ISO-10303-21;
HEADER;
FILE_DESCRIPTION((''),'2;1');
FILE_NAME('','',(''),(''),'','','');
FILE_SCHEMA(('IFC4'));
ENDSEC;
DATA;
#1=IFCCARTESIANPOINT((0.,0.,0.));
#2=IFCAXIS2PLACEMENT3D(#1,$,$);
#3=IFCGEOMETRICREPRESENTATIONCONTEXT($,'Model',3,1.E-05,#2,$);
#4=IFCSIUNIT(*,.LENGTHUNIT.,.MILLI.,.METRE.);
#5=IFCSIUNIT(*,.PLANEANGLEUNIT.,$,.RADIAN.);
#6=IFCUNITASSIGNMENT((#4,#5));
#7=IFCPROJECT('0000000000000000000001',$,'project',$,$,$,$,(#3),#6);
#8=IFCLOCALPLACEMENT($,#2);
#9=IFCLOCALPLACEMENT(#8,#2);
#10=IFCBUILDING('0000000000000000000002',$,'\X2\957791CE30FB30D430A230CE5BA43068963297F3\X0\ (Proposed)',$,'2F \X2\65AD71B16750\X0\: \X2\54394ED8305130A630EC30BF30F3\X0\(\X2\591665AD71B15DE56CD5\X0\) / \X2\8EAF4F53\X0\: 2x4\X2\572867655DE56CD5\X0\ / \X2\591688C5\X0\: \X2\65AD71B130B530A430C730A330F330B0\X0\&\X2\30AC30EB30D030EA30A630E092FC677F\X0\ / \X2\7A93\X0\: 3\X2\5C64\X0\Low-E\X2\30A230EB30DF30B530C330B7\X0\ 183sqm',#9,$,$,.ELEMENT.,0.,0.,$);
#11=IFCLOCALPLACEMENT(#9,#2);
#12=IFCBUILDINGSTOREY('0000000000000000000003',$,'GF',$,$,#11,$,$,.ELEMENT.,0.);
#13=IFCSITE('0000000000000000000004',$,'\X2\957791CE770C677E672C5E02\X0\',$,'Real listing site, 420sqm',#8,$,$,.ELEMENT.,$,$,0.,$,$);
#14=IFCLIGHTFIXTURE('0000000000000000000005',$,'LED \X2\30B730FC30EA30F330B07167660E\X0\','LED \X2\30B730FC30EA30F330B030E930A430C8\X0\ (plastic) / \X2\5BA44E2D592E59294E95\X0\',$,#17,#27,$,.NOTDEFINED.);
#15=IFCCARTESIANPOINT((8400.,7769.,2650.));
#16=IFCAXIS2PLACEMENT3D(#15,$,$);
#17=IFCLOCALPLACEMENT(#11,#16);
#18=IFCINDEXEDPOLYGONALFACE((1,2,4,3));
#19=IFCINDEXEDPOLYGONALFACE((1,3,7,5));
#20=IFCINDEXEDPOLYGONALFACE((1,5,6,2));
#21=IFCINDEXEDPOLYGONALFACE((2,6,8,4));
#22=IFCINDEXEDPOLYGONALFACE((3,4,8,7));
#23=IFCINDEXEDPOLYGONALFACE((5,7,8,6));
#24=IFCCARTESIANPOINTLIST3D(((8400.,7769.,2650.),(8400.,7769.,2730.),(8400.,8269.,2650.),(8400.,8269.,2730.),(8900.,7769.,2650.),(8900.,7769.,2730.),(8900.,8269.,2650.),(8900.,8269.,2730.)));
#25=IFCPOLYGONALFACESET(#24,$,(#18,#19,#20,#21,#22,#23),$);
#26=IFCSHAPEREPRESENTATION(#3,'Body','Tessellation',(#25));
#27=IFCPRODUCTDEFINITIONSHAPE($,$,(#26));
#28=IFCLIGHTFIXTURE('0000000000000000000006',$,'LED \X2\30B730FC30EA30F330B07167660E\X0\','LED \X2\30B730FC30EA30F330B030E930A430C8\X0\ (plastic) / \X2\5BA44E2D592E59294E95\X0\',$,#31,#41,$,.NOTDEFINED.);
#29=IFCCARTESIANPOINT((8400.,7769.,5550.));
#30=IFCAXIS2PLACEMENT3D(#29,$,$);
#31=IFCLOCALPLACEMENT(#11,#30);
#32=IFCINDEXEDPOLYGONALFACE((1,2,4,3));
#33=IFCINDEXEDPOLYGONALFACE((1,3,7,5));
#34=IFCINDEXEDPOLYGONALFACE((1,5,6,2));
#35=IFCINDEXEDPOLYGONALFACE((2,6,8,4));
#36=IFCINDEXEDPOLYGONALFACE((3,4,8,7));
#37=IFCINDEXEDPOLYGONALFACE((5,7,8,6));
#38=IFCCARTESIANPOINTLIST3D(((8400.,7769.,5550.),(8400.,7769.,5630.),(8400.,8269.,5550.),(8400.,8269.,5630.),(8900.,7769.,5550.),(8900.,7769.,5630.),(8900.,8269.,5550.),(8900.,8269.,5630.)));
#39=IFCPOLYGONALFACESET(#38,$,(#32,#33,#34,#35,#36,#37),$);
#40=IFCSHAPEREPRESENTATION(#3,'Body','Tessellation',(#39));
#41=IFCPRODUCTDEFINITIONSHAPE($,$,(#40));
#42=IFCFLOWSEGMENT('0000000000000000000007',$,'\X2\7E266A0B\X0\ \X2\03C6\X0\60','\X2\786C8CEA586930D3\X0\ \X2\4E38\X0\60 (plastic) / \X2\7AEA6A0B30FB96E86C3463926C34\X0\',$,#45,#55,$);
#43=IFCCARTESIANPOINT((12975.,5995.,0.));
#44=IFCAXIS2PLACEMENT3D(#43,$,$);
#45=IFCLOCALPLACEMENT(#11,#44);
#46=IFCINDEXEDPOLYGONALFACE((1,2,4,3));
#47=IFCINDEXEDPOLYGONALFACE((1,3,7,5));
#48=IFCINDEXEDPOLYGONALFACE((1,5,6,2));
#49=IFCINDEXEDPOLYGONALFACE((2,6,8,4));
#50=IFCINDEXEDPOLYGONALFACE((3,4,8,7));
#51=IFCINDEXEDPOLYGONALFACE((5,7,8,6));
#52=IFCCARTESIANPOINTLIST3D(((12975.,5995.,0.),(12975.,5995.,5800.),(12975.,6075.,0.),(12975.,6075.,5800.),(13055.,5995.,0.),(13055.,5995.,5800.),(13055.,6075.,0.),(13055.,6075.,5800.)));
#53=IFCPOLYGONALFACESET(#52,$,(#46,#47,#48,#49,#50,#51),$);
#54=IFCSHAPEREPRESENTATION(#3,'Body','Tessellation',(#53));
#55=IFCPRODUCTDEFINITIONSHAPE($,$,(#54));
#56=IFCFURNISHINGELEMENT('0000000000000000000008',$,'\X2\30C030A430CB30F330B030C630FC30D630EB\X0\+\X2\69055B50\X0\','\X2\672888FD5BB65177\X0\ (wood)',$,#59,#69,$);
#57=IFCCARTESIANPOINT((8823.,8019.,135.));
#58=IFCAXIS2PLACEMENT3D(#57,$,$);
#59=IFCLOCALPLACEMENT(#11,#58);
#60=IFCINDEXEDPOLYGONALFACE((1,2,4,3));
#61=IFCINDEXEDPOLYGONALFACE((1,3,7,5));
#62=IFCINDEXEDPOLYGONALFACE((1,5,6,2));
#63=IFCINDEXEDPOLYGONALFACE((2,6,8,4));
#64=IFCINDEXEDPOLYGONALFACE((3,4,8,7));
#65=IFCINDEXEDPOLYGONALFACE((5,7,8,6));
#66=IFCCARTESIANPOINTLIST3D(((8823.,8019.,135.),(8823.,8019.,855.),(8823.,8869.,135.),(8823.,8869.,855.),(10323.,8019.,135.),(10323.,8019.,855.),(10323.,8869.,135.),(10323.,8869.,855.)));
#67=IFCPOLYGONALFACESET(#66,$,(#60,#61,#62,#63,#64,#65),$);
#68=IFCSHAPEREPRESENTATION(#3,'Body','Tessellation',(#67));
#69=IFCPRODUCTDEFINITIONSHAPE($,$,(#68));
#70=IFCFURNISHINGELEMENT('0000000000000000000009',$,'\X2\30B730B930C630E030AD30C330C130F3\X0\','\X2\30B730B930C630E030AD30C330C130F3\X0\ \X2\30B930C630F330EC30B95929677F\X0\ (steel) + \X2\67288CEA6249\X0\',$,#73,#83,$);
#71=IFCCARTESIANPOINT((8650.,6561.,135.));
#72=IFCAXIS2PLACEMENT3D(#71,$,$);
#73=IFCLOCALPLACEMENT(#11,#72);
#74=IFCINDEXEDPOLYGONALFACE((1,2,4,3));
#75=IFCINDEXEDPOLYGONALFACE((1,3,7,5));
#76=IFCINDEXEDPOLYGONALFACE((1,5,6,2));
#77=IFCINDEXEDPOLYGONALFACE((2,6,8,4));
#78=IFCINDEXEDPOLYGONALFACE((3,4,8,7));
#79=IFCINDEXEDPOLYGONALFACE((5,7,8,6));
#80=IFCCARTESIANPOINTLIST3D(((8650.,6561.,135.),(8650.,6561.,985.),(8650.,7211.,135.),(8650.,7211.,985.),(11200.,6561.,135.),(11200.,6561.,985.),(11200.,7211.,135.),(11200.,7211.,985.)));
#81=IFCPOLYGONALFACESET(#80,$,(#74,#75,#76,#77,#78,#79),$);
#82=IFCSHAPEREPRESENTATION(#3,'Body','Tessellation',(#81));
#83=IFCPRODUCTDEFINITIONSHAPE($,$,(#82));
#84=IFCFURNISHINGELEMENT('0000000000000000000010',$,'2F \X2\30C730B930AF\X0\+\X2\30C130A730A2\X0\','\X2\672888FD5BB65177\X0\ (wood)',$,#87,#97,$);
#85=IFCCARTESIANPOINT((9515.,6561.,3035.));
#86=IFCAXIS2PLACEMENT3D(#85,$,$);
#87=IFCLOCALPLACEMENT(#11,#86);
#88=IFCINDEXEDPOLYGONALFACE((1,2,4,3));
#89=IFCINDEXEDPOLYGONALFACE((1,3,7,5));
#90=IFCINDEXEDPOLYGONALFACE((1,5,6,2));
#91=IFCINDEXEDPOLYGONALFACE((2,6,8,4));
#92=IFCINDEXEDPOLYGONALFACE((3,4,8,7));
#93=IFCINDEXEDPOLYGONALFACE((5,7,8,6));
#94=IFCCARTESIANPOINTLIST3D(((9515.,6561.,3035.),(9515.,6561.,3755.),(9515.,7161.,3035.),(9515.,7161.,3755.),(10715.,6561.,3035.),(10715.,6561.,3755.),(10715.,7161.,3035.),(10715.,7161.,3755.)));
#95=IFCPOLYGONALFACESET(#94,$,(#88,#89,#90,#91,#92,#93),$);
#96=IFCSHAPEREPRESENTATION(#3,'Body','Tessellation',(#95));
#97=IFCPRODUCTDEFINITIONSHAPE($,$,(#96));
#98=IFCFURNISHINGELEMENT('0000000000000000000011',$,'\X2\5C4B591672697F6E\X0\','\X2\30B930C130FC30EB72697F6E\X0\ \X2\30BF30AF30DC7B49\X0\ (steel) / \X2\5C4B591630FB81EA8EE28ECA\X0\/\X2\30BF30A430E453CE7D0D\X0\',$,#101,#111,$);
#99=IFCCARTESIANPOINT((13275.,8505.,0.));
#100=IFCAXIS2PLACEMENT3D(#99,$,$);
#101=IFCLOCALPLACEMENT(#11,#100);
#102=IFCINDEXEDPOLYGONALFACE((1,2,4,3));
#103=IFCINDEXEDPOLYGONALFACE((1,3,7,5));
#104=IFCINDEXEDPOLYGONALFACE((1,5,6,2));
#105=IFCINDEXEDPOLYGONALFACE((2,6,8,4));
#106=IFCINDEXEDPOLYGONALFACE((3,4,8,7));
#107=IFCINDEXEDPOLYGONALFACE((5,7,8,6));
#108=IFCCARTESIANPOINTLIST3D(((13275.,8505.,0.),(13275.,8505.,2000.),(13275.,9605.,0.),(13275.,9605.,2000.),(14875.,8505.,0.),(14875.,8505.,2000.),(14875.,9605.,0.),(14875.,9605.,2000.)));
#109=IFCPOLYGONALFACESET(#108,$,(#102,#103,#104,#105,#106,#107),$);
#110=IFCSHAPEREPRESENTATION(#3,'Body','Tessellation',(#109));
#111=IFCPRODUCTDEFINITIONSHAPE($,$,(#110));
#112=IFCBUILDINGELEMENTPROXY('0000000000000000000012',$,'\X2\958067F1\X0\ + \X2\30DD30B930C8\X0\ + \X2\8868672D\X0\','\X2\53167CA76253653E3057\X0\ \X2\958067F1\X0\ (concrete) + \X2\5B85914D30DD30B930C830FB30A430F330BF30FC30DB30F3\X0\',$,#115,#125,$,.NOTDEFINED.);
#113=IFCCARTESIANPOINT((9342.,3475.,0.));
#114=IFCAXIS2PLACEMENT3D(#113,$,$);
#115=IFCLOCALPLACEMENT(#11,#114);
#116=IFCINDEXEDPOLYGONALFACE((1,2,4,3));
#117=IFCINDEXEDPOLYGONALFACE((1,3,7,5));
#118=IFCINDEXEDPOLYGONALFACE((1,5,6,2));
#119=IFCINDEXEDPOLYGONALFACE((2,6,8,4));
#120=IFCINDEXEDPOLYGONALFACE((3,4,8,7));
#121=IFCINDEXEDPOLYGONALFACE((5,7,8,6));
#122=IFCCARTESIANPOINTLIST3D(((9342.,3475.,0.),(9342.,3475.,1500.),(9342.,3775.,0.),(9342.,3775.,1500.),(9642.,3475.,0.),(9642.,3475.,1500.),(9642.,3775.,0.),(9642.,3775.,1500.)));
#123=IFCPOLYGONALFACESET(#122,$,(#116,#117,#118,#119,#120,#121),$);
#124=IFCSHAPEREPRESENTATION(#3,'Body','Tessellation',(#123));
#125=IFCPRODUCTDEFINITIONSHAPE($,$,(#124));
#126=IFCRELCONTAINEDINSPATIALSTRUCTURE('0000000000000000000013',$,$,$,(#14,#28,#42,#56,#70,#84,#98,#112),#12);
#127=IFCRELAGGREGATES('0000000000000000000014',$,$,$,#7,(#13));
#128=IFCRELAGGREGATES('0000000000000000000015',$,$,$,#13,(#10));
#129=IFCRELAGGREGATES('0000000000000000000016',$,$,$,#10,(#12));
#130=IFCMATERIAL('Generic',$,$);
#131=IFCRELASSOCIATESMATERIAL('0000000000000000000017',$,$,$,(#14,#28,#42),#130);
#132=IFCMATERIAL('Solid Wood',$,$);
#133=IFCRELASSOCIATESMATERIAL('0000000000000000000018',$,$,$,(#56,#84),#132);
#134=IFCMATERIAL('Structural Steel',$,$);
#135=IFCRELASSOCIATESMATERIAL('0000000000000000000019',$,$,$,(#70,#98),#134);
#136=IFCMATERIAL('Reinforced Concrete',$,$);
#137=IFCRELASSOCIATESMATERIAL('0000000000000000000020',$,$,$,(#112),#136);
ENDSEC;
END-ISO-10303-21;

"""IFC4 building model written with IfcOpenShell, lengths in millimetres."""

from ifc_helpers import new_model, si_unit, frame, frame_2d, origin, place, context, project, spatial, rectangle, extrude, material, element, save


model = new_model("IFC4")

# Units and contexts
model_context = context("Model", 3, precision=1e-05, world=origin())
ifc_project = project(units=[si_unit("LENGTHUNIT", "METRE", prefix="MILLI"), si_unit("PLANEANGLEUNIT", "RADIAN")], contexts=[model_context])

# Site, building, storey
site_placement = place(None, origin())
site = spatial("IfcSite", under=ifc_project, at=site_placement, Name="長野県松本市", ObjectType="Real listing site, 420sqm", CompositionType="ELEMENT", RefElevation=0.0)
building_placement = place(site_placement, origin())
building = spatial("IfcBuilding", under=site, at=building_placement, Name="長野・ピアノ室と防音 (Proposed)", ObjectType="2F 断熱材: 吹付けウレタン(外断熱工法) / 躯体: 2x4在来工法 / 外装: 断熱サイディング&ガルバリウム鋼板 / 窓: 3層Low-Eアルミサッシ 183sqm", CompositionType="ELEMENT", ElevationOfRefHeight=0.0, ElevationOfTerrain=0.0)
storey_placement = place(building_placement, origin())
storey = spatial("IfcBuildingStorey", under=building, at=storey_placement, Name="GF", CompositionType="ELEMENT", Elevation=0.0)

# Shared definitions
ifc_material_1 = material(Name="Solid Wood")

# Shared definitions
ifc_material_2 = material(Name="Reinforced Concrete")

# Shared definitions
ifc_material_3 = material(Name="Structural Steel")

# Shared definitions
ifc_material_4 = material(Name="Generic")

# Light fixtures
light_fixture_1_placement = place(storey_placement, frame((8400.0, 7769.0, 2650.0)))
element("IfcLightFixture", 1, at=light_fixture_1_placement, inside=storey, material=ifc_material_4, Name="LED シーリング照明", Description="LED シーリングライト (plastic) / 室中央天井", PredefinedType="NOTDEFINED", context=model_context, shape_type="SweptSolid", body=[
    extrude(rectangle(XDim=500.0, YDim=500.0, at=frame_2d((250.0, 250.0))), frame((8400.0, 7769.0, 2650.0)), (0.0, 0.0, 1.0), 80.0),
])
light_fixture_2_placement = place(storey_placement, frame((8400.0, 7769.0, 5550.0)))
element("IfcLightFixture", 2, at=light_fixture_2_placement, inside=storey, material=ifc_material_4, Name="LED シーリング照明", Description="LED シーリングライト (plastic) / 室中央天井", PredefinedType="NOTDEFINED", context=model_context, shape_type="SweptSolid", body=[
    extrude(rectangle(XDim=500.0, YDim=500.0, at=frame_2d((250.0, 250.0))), frame((8400.0, 7769.0, 5550.0)), (0.0, 0.0, 1.0), 80.0),
])

# Flow segment
flow_segment_placement = place(storey_placement, frame((12975.0, 5995.0, 0.0)))
element("IfcFlowSegment", 3, at=flow_segment_placement, inside=storey, material=ifc_material_4, Name="縦樋 φ60", Description="硬質塩ビ 丸60 (plastic) / 竪樋・雨水排水", context=model_context, shape_type="SweptSolid", body=[
    extrude(rectangle(XDim=80.0, YDim=80.0, at=frame_2d((40.0, 40.0))), frame((12975.0, 5995.0, 0.0)), (0.0, 0.0, 1.0), 5800.0),
])

# Furnishing elements
furnishing_1_placement = place(storey_placement, frame((8823.0, 8019.0, 135.0)))
element("IfcFurnishingElement", 4, at=furnishing_1_placement, inside=storey, material=ifc_material_1, Name="ダイニングテーブル+椅子", Description="木製家具 (wood)", context=model_context, shape_type="SweptSolid", body=[
    extrude(rectangle(XDim=1500.0, YDim=850.0, at=frame_2d((750.0, 425.0))), frame((8823.0, 8019.0, 135.0)), (0.0, 0.0, 1.0), 720.0),
])
furnishing_2_placement = place(storey_placement, frame((8650.0, 6561.0, 135.0)))
element("IfcFurnishingElement", 5, at=furnishing_2_placement, inside=storey, material=ifc_material_3, Name="システムキッチン", Description="システムキッチン ステンレス天板 (steel) + 木質扉", context=model_context, shape_type="SweptSolid", body=[
    extrude(rectangle(XDim=2550.0, YDim=650.0, at=frame_2d((1275.0, 325.0))), frame((8650.0, 6561.0, 135.0)), (0.0, 0.0, 1.0), 850.0),
])
furnishing_3_placement = place(storey_placement, frame((9515.0, 6561.0, 3035.0)))
element("IfcFurnishingElement", 6, at=furnishing_3_placement, inside=storey, material=ifc_material_1, Name="2F デスク+チェア", Description="木製家具 (wood)", context=model_context, shape_type="SweptSolid", body=[
    extrude(rectangle(XDim=1200.0, YDim=600.0, at=frame_2d((600.0, 300.0))), frame((9515.0, 6561.0, 3035.0)), (0.0, 0.0, 1.0), 720.0),
])
furnishing_4_placement = place(storey_placement, frame((13275.0, 8505.0, 0.0)))
element("IfcFurnishingElement", 7, at=furnishing_4_placement, inside=storey, material=ifc_material_3, Name="屋外物置", Description="スチール物置 タクボ等 (steel) / 屋外・自転車/タイヤ収納", context=model_context, shape_type="SweptSolid", body=[
    extrude(rectangle(XDim=1600.0, YDim=1100.0, at=frame_2d((800.0, 550.0))), frame((13275.0, 8505.0, 0.0)), (0.0, 0.0, 1.0), 2000.0),
])

# Building element proxy
proxy_placement = place(storey_placement, frame((9342.0, 3475.0, 0.0)))
element("IfcBuildingElementProxy", 8, at=proxy_placement, inside=storey, material=ifc_material_2, Name="門柱 + ポスト + 表札", Description="化粧打放し 門柱 (concrete) + 宅配ポスト・インターホン", PredefinedType="NOTDEFINED", context=model_context, shape_type="SweptSolid", body=[
    extrude(rectangle(XDim=300.0, YDim=300.0, at=frame_2d((150.0, 150.0))), frame((9342.0, 3475.0, 0.0)), (0.0, 0.0, 1.0), 1500.0),
])

save(model, "model.ifc")
